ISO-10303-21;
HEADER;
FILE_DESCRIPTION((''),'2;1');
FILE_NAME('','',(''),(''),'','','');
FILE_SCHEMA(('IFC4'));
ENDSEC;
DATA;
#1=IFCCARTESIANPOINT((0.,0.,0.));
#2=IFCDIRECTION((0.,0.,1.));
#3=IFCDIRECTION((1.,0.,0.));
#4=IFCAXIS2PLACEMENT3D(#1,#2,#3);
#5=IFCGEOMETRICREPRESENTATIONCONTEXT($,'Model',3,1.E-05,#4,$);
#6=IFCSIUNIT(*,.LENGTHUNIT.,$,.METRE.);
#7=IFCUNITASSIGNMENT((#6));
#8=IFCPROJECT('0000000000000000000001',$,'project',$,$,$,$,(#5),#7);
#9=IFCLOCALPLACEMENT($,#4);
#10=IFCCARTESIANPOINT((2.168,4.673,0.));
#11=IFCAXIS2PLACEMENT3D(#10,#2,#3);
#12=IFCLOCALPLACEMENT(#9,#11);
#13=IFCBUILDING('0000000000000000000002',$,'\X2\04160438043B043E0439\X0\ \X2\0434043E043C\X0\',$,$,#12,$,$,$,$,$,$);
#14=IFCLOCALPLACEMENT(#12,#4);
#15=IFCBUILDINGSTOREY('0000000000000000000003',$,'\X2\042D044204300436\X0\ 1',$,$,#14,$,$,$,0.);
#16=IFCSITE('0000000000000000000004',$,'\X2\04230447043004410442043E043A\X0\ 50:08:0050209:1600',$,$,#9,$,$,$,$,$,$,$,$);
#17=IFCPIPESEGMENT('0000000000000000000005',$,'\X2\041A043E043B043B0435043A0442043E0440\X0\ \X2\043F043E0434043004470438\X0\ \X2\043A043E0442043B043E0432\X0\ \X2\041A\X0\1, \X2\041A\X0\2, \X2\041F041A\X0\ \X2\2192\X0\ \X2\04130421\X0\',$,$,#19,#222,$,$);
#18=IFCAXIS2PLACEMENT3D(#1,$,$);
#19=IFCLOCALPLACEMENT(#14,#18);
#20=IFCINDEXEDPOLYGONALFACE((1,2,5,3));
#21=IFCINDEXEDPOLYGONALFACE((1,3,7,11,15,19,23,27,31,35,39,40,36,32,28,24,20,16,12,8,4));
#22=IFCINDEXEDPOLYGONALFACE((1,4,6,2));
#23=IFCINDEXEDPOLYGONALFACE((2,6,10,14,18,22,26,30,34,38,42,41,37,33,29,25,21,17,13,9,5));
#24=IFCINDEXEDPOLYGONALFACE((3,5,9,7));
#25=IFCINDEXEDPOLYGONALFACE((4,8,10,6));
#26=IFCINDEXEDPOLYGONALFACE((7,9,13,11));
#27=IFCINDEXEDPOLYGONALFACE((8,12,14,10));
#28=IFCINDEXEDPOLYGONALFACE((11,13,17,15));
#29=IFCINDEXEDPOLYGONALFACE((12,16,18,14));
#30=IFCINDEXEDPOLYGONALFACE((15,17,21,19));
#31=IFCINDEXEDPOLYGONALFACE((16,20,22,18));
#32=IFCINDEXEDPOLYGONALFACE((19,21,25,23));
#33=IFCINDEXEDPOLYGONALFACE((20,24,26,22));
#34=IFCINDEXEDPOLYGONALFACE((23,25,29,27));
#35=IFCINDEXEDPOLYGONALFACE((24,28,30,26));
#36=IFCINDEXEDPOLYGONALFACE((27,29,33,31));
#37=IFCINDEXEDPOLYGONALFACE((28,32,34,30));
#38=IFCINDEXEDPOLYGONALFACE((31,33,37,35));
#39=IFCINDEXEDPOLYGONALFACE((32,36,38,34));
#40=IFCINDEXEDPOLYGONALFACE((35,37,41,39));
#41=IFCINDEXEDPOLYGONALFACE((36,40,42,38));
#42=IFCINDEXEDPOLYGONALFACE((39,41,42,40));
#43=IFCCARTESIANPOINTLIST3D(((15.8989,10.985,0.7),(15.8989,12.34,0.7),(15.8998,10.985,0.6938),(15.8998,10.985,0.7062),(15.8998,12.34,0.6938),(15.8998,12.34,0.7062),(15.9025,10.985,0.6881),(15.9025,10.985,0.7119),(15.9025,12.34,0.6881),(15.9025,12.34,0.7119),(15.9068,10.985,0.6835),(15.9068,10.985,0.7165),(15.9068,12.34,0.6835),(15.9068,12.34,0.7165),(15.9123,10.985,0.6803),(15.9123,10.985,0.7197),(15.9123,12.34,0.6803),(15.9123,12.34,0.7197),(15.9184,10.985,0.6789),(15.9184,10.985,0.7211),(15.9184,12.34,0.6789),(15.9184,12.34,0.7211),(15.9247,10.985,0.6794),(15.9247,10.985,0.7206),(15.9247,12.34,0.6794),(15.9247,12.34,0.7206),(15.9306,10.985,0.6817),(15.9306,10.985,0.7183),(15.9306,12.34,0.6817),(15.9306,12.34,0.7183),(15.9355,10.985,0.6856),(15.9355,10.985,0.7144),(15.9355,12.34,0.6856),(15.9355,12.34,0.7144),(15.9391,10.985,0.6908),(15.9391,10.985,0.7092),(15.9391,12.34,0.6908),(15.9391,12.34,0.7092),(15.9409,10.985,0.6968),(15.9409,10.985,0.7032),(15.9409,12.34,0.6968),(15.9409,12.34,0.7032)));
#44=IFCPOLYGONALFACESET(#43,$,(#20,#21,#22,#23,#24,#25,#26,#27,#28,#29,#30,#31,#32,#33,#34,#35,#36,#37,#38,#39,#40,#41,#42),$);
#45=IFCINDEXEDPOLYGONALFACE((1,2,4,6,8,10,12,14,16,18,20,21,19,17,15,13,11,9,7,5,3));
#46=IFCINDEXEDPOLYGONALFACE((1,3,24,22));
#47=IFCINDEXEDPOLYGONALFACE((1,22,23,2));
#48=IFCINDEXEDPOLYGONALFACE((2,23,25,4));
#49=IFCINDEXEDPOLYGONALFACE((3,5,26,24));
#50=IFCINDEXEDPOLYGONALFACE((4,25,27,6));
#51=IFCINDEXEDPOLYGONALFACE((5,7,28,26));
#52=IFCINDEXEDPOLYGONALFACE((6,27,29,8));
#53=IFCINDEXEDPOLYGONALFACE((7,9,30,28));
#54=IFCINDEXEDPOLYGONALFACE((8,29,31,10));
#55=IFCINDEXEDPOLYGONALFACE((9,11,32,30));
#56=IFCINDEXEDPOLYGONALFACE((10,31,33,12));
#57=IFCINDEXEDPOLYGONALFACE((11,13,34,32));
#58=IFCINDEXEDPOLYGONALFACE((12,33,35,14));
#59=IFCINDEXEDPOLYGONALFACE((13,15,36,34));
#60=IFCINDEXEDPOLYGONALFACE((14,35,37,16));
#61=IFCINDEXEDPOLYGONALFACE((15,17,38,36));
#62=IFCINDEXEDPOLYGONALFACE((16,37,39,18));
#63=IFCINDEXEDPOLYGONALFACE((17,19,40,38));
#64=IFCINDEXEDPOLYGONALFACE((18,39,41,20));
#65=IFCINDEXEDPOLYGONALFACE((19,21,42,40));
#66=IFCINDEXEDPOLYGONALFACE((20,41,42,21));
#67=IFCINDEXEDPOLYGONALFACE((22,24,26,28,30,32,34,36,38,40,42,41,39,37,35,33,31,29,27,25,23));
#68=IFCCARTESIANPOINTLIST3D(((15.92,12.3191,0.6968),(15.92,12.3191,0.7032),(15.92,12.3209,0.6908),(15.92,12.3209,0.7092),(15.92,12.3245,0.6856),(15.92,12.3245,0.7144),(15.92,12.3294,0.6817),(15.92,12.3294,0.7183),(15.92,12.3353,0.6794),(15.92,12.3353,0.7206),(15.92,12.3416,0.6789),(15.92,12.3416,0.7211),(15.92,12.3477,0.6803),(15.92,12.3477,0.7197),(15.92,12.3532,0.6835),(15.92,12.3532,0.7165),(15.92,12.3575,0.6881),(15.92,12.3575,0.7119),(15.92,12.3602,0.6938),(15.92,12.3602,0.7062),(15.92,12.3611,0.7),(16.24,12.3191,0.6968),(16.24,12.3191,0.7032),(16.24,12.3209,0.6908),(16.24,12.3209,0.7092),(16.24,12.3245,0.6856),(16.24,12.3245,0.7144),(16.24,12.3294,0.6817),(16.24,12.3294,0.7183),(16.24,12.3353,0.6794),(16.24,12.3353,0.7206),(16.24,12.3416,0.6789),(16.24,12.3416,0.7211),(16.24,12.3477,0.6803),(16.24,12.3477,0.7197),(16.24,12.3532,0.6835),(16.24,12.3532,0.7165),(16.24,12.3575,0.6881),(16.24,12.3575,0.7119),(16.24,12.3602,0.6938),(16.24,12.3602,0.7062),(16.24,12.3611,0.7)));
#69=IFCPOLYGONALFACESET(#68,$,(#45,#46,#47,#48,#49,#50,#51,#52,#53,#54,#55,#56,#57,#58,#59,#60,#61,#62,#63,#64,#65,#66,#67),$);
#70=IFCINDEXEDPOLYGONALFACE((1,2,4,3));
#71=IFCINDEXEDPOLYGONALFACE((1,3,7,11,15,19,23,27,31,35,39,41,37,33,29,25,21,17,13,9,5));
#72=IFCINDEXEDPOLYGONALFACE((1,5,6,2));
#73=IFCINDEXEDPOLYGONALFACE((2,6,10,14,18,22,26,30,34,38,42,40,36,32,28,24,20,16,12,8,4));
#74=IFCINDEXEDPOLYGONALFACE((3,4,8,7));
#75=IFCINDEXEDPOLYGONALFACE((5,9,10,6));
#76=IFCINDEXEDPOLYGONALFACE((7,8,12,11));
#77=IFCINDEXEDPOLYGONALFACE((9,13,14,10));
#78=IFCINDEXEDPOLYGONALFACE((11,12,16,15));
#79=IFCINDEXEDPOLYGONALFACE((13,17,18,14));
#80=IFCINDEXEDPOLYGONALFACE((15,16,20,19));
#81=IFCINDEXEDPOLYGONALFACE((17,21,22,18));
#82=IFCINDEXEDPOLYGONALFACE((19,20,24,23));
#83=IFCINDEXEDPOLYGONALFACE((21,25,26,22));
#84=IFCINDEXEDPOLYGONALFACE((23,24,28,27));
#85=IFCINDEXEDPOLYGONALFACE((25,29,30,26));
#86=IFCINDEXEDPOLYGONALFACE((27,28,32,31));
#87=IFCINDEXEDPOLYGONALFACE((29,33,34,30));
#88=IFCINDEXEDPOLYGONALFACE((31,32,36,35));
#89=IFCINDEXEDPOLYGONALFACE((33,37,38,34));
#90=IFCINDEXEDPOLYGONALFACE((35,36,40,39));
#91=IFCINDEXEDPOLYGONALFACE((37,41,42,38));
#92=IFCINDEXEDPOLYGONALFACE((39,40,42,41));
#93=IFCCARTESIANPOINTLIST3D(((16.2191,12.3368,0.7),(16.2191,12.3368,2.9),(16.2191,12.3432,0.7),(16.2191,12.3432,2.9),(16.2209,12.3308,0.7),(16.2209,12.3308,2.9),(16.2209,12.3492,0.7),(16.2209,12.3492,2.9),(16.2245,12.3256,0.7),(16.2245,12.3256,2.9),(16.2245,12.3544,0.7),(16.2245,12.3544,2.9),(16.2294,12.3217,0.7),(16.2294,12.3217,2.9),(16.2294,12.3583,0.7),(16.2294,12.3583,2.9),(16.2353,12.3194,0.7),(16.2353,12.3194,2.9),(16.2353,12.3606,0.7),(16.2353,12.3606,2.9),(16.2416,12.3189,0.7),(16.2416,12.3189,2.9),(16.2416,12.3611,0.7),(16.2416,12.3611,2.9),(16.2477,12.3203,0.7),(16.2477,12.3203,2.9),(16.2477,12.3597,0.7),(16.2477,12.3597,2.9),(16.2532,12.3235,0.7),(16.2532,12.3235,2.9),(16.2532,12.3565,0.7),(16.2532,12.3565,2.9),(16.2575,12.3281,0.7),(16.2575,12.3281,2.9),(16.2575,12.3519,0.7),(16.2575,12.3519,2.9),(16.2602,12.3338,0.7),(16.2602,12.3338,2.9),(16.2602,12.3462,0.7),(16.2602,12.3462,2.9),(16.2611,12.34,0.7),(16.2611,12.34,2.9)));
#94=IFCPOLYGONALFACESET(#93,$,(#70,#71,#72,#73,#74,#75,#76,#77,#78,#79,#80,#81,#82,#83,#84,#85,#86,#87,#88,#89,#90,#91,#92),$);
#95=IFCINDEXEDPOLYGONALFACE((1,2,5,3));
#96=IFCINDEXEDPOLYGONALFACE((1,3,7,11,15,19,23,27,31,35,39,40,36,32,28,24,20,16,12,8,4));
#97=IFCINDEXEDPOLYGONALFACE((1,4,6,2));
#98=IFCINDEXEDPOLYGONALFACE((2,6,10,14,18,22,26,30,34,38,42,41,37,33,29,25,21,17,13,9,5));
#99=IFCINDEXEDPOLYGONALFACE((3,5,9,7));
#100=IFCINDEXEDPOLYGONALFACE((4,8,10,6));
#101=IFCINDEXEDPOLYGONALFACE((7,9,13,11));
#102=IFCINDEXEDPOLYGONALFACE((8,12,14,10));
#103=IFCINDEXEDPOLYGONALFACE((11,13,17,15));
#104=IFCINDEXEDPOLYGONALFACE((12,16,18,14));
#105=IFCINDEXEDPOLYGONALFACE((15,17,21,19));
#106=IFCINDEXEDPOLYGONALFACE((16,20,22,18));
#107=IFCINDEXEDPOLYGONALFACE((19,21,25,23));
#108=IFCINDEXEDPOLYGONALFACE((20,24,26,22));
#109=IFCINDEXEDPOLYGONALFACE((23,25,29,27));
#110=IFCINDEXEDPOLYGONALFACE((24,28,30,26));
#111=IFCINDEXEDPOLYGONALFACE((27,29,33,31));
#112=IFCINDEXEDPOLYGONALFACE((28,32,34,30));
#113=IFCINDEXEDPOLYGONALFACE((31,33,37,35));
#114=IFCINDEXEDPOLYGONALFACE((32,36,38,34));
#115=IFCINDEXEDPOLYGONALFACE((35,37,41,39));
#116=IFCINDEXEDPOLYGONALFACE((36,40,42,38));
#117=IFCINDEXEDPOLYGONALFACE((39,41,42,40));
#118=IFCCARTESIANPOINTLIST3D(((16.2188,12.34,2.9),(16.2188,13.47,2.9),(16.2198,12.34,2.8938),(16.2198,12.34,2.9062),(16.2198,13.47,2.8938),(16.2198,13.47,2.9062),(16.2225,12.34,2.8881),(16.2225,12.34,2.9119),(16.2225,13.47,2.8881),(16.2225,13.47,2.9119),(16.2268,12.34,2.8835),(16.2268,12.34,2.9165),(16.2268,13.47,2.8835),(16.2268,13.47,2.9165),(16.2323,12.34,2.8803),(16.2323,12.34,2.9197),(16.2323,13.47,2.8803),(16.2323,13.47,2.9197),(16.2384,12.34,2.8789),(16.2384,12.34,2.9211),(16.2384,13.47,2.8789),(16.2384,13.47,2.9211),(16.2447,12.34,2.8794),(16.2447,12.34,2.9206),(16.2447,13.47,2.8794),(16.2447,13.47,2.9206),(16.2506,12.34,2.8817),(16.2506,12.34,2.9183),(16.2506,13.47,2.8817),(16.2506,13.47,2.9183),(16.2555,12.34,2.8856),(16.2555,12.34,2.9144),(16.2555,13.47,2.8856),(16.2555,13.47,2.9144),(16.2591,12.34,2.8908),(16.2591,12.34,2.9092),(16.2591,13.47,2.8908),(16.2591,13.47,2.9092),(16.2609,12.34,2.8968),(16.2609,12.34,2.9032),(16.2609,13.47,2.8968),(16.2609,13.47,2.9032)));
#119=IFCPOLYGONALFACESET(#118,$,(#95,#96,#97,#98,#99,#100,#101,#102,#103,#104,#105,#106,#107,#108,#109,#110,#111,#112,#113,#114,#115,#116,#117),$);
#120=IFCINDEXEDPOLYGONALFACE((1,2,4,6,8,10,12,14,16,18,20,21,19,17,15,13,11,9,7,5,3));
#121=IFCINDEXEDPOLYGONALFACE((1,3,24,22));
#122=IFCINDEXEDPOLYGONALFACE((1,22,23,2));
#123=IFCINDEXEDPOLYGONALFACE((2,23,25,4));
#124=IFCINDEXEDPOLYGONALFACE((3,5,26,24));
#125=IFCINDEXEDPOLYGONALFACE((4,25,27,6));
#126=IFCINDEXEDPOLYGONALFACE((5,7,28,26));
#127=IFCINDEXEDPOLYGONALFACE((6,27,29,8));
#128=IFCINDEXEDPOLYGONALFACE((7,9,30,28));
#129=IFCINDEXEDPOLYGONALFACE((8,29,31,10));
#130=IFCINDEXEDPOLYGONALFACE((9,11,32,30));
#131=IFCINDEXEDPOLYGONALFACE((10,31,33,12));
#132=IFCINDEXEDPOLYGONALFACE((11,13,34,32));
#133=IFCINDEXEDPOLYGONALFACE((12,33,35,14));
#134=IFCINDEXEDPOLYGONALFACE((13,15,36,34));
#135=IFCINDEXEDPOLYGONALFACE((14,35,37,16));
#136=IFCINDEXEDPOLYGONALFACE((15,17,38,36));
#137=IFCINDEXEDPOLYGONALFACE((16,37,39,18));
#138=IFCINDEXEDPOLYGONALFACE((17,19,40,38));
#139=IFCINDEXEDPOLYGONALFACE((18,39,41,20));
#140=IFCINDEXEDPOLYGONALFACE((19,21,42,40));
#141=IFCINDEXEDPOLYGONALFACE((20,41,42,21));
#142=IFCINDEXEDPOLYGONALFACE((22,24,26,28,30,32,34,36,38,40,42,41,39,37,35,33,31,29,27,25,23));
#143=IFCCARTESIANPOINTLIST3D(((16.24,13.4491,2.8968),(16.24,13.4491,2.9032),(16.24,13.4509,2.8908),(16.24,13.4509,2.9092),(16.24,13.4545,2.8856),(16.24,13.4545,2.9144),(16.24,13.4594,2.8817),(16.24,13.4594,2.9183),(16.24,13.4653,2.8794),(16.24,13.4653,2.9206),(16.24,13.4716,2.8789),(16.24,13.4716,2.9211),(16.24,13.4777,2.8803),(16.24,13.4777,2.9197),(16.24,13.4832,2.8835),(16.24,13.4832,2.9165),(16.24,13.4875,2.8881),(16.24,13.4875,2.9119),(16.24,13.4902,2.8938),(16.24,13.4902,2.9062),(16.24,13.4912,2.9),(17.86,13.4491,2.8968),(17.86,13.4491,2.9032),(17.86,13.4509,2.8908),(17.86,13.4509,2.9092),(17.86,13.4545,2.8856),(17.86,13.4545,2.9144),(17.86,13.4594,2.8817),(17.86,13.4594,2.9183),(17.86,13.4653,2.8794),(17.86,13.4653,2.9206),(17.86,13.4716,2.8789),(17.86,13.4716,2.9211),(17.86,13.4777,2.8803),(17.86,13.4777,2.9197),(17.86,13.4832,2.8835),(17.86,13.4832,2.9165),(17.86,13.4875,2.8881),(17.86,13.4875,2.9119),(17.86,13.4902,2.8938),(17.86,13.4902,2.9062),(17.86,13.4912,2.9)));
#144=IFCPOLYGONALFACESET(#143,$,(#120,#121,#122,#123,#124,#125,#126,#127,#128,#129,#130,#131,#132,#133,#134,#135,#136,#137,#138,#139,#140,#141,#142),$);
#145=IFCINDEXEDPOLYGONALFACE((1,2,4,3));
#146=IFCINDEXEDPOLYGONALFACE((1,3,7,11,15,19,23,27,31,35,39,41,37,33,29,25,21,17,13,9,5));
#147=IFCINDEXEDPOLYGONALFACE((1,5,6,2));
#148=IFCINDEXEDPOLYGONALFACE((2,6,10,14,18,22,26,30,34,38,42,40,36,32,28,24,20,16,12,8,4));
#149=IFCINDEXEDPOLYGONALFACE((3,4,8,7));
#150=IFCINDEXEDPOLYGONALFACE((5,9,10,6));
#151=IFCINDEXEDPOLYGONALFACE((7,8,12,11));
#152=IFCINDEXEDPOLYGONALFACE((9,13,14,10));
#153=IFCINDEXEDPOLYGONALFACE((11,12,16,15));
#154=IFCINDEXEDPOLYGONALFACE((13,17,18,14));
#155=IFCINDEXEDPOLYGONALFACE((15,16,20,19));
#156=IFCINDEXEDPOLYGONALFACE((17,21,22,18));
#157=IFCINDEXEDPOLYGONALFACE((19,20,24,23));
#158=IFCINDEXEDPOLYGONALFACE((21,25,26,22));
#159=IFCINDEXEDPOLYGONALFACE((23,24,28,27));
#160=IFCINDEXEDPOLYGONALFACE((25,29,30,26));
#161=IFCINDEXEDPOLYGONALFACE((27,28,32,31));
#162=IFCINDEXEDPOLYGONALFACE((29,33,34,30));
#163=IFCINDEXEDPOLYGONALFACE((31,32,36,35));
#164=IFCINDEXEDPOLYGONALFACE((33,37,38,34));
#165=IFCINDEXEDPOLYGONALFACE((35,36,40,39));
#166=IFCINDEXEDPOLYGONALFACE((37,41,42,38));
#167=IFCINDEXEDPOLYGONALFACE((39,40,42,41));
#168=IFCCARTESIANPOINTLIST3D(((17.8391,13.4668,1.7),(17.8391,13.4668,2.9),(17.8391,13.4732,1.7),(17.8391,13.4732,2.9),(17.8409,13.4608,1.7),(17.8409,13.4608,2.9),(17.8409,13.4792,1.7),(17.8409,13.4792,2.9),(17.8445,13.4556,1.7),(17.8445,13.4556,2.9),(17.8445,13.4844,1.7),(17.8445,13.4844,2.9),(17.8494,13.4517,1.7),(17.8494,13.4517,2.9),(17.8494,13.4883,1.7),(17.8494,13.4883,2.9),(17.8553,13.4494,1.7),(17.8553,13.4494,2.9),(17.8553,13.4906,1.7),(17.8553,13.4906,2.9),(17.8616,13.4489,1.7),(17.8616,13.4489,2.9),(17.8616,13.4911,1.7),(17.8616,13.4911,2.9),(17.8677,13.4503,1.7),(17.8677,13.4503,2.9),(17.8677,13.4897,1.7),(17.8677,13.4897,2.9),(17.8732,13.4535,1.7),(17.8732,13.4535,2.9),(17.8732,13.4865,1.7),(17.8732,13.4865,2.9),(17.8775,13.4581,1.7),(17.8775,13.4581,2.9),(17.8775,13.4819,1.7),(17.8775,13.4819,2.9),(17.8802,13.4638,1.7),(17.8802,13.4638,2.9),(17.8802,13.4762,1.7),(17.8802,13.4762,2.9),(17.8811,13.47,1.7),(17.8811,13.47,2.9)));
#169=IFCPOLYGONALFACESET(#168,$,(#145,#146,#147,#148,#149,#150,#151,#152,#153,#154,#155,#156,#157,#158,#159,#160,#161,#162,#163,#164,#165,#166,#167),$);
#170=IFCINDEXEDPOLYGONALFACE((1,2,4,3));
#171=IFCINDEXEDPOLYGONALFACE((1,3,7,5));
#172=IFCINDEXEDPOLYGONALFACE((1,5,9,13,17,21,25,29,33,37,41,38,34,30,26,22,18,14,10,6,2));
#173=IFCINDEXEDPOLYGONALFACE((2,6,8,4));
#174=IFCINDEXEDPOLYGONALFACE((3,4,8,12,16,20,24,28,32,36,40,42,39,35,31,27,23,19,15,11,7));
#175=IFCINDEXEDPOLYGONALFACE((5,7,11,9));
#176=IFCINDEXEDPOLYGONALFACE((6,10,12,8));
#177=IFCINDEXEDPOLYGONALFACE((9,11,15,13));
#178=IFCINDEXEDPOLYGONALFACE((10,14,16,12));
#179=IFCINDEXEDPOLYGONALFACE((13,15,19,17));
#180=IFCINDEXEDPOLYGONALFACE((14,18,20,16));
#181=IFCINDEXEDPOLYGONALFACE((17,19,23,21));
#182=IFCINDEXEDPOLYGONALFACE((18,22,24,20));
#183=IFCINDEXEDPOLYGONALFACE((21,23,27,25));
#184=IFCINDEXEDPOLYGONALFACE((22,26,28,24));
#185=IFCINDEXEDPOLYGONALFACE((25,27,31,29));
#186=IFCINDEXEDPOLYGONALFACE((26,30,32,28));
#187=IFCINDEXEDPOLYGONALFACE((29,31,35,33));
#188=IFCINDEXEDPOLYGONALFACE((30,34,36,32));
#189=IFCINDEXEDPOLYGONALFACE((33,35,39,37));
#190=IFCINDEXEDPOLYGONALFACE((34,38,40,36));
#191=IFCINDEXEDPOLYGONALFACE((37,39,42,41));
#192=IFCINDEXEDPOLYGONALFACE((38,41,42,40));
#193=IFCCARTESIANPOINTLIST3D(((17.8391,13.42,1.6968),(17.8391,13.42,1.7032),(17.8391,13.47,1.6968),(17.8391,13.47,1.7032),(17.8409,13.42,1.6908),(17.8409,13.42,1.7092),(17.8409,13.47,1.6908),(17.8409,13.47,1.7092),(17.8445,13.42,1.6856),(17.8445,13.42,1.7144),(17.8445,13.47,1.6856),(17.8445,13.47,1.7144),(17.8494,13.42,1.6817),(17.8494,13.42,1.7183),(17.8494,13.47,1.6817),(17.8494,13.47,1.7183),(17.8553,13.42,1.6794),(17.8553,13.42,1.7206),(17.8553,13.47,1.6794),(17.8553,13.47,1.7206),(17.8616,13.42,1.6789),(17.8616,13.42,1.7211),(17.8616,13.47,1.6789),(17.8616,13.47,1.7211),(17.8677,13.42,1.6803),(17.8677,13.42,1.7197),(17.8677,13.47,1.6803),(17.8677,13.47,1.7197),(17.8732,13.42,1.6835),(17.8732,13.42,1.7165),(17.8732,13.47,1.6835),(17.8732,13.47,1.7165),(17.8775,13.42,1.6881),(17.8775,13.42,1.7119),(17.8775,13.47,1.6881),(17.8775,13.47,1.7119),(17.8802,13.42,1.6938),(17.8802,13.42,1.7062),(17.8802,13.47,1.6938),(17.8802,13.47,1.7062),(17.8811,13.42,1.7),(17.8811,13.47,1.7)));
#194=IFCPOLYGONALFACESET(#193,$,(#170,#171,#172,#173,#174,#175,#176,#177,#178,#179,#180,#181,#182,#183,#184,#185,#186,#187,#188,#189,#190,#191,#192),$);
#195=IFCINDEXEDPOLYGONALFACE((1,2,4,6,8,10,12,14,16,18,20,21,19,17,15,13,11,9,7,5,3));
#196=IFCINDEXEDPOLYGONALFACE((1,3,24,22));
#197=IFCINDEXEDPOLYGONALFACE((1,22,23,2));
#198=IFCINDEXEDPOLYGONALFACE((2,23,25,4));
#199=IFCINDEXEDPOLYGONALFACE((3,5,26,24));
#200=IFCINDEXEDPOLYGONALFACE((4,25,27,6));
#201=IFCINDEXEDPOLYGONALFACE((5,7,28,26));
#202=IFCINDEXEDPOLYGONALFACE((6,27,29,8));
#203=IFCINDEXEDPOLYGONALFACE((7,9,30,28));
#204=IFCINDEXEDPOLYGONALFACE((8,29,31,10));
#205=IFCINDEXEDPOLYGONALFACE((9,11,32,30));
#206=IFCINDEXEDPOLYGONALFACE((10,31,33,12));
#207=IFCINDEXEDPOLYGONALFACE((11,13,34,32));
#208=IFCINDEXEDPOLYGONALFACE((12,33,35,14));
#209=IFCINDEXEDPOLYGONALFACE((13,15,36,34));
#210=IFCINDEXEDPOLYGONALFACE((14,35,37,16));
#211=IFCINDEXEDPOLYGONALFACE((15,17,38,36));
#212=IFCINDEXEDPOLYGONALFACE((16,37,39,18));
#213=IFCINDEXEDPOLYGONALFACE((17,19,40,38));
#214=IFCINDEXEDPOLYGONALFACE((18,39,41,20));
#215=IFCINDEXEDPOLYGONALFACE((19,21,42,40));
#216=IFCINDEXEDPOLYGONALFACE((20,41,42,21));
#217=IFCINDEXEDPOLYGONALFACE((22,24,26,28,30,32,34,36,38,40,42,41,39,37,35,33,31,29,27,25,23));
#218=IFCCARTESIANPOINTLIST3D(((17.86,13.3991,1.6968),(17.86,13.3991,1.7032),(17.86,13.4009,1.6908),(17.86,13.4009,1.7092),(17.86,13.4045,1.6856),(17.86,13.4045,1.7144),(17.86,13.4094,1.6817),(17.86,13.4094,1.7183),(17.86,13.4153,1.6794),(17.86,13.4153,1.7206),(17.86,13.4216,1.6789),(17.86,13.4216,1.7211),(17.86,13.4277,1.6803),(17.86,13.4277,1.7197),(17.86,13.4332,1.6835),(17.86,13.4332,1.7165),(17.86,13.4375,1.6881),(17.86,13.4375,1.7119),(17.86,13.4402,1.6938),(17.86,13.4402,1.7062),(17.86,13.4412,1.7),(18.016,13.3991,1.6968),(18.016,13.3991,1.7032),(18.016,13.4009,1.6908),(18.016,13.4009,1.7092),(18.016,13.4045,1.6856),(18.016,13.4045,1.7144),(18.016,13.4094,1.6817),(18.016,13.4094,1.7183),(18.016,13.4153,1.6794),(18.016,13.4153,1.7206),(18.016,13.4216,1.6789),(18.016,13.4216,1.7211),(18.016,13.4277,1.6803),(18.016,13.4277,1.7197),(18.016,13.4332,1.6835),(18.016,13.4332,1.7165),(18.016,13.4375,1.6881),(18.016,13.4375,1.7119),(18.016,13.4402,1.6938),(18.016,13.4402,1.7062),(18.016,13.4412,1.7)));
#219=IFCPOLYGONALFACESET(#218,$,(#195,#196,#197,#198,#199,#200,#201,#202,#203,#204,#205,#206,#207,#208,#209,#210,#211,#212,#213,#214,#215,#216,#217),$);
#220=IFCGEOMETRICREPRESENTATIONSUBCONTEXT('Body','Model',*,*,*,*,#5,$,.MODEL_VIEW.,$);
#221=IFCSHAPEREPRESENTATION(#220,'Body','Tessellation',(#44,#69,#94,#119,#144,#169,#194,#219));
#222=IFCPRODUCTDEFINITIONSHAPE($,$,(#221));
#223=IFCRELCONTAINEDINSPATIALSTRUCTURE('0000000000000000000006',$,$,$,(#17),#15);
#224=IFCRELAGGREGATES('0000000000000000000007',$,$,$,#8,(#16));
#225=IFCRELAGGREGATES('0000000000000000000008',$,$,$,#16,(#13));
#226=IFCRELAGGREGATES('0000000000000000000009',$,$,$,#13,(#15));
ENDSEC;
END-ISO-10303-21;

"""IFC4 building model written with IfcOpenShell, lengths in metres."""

from ifc_helpers import new_model, si_unit, frame, origin_with_axes, origin_2d, place, context, subcontext, project, spatial, circle, extrude, element, save


model = new_model("IFC4")

# Units and contexts
model_context = context("Model", 3, precision=1e-05, world=origin_with_axes())
body_context = subcontext(model_context, "Body", "Model", "MODEL_VIEW")
ifc_project = project(units=[si_unit("LENGTHUNIT", "METRE")], contexts=[model_context])

# Site, building, storey
site_placement = place(None, origin_with_axes())
site = spatial("IfcSite", under=ifc_project, at=site_placement, Name="Участок 50:08:0050209:1600")
building_placement = place(site_placement, frame((2.168, 4.673, 0.0), z_axis=(0.0, 0.0, 1.0), x_axis=(1.0, 0.0, 0.0)))
building = spatial("IfcBuilding", under=site, at=building_placement, Name="Жилой дом")
storey_placement = place(building_placement, origin_with_axes())
storey = spatial("IfcBuildingStorey", under=building, at=storey_placement, Name="Этаж 1", Elevation=0.0)

# Pipe segment
pipe_segment_1_placement = place(storey_placement, origin_with_axes())
element("IfcPipeSegment", 1, at=pipe_segment_1_placement, inside=storey, Name="Коллектор подачи котлов К1, К2, ПК → ГС", context=body_context, shape_type="SweptSolid", body=[
    extrude(circle(Radius=0.0211, at=origin_2d()), frame((15.92, 10.985, 0.7), z_axis=(0.0, 1.0, 0.0), x_axis=(-1.0, 0.0, 0.0)), (0.0, 0.0, 1.0), 1.355),
    extrude(circle(Radius=0.0211, at=origin_2d()), frame((15.92, 12.34, 0.7), z_axis=(1.0, 0.0, 0.0), x_axis=(0.0, 1.0, 0.0)), (0.0, 0.0, 1.0), 0.32),
    extrude(circle(Radius=0.0211, at=origin_2d()), frame((16.24, 12.34, 0.7), z_axis=(0.0, 0.0, 1.0), x_axis=(1.0, 0.0, 0.0)), (0.0, 0.0, 1.0), 2.2),
    extrude(circle(Radius=0.0211, at=origin_2d()), frame((16.24, 12.34, 2.9), z_axis=(0.0, 1.0, 0.0), x_axis=(-1.0, 0.0, 0.0)), (0.0, 0.0, 1.0), 1.13),
    extrude(circle(Radius=0.0211, at=origin_2d()), frame((16.24, 13.47, 2.9), z_axis=(1.0, 0.0, 0.0), x_axis=(0.0, 1.0, 0.0)), (0.0, 0.0, 1.0), 1.62),
    extrude(circle(Radius=0.0211, at=origin_2d()), frame((17.86, 13.47, 2.9), z_axis=(0.0, 0.0, -1.0), x_axis=(1.0, 0.0, 0.0)), (0.0, 0.0, 1.0), 1.2),
    extrude(circle(Radius=0.0211, at=origin_2d()), frame((17.86, 13.47, 1.7), z_axis=(0.0, -1.0, 0.0), x_axis=(1.0, 0.0, 0.0)), (0.0, 0.0, 1.0), 0.05),
    extrude(circle(Radius=0.0211, at=origin_2d()), frame((17.86, 13.42, 1.7), z_axis=(1.0, 0.0, 0.0), x_axis=(0.0, 1.0, 0.0)), (0.0, 0.0, 1.0), 0.156),
])

save(model, "model.ifc")
